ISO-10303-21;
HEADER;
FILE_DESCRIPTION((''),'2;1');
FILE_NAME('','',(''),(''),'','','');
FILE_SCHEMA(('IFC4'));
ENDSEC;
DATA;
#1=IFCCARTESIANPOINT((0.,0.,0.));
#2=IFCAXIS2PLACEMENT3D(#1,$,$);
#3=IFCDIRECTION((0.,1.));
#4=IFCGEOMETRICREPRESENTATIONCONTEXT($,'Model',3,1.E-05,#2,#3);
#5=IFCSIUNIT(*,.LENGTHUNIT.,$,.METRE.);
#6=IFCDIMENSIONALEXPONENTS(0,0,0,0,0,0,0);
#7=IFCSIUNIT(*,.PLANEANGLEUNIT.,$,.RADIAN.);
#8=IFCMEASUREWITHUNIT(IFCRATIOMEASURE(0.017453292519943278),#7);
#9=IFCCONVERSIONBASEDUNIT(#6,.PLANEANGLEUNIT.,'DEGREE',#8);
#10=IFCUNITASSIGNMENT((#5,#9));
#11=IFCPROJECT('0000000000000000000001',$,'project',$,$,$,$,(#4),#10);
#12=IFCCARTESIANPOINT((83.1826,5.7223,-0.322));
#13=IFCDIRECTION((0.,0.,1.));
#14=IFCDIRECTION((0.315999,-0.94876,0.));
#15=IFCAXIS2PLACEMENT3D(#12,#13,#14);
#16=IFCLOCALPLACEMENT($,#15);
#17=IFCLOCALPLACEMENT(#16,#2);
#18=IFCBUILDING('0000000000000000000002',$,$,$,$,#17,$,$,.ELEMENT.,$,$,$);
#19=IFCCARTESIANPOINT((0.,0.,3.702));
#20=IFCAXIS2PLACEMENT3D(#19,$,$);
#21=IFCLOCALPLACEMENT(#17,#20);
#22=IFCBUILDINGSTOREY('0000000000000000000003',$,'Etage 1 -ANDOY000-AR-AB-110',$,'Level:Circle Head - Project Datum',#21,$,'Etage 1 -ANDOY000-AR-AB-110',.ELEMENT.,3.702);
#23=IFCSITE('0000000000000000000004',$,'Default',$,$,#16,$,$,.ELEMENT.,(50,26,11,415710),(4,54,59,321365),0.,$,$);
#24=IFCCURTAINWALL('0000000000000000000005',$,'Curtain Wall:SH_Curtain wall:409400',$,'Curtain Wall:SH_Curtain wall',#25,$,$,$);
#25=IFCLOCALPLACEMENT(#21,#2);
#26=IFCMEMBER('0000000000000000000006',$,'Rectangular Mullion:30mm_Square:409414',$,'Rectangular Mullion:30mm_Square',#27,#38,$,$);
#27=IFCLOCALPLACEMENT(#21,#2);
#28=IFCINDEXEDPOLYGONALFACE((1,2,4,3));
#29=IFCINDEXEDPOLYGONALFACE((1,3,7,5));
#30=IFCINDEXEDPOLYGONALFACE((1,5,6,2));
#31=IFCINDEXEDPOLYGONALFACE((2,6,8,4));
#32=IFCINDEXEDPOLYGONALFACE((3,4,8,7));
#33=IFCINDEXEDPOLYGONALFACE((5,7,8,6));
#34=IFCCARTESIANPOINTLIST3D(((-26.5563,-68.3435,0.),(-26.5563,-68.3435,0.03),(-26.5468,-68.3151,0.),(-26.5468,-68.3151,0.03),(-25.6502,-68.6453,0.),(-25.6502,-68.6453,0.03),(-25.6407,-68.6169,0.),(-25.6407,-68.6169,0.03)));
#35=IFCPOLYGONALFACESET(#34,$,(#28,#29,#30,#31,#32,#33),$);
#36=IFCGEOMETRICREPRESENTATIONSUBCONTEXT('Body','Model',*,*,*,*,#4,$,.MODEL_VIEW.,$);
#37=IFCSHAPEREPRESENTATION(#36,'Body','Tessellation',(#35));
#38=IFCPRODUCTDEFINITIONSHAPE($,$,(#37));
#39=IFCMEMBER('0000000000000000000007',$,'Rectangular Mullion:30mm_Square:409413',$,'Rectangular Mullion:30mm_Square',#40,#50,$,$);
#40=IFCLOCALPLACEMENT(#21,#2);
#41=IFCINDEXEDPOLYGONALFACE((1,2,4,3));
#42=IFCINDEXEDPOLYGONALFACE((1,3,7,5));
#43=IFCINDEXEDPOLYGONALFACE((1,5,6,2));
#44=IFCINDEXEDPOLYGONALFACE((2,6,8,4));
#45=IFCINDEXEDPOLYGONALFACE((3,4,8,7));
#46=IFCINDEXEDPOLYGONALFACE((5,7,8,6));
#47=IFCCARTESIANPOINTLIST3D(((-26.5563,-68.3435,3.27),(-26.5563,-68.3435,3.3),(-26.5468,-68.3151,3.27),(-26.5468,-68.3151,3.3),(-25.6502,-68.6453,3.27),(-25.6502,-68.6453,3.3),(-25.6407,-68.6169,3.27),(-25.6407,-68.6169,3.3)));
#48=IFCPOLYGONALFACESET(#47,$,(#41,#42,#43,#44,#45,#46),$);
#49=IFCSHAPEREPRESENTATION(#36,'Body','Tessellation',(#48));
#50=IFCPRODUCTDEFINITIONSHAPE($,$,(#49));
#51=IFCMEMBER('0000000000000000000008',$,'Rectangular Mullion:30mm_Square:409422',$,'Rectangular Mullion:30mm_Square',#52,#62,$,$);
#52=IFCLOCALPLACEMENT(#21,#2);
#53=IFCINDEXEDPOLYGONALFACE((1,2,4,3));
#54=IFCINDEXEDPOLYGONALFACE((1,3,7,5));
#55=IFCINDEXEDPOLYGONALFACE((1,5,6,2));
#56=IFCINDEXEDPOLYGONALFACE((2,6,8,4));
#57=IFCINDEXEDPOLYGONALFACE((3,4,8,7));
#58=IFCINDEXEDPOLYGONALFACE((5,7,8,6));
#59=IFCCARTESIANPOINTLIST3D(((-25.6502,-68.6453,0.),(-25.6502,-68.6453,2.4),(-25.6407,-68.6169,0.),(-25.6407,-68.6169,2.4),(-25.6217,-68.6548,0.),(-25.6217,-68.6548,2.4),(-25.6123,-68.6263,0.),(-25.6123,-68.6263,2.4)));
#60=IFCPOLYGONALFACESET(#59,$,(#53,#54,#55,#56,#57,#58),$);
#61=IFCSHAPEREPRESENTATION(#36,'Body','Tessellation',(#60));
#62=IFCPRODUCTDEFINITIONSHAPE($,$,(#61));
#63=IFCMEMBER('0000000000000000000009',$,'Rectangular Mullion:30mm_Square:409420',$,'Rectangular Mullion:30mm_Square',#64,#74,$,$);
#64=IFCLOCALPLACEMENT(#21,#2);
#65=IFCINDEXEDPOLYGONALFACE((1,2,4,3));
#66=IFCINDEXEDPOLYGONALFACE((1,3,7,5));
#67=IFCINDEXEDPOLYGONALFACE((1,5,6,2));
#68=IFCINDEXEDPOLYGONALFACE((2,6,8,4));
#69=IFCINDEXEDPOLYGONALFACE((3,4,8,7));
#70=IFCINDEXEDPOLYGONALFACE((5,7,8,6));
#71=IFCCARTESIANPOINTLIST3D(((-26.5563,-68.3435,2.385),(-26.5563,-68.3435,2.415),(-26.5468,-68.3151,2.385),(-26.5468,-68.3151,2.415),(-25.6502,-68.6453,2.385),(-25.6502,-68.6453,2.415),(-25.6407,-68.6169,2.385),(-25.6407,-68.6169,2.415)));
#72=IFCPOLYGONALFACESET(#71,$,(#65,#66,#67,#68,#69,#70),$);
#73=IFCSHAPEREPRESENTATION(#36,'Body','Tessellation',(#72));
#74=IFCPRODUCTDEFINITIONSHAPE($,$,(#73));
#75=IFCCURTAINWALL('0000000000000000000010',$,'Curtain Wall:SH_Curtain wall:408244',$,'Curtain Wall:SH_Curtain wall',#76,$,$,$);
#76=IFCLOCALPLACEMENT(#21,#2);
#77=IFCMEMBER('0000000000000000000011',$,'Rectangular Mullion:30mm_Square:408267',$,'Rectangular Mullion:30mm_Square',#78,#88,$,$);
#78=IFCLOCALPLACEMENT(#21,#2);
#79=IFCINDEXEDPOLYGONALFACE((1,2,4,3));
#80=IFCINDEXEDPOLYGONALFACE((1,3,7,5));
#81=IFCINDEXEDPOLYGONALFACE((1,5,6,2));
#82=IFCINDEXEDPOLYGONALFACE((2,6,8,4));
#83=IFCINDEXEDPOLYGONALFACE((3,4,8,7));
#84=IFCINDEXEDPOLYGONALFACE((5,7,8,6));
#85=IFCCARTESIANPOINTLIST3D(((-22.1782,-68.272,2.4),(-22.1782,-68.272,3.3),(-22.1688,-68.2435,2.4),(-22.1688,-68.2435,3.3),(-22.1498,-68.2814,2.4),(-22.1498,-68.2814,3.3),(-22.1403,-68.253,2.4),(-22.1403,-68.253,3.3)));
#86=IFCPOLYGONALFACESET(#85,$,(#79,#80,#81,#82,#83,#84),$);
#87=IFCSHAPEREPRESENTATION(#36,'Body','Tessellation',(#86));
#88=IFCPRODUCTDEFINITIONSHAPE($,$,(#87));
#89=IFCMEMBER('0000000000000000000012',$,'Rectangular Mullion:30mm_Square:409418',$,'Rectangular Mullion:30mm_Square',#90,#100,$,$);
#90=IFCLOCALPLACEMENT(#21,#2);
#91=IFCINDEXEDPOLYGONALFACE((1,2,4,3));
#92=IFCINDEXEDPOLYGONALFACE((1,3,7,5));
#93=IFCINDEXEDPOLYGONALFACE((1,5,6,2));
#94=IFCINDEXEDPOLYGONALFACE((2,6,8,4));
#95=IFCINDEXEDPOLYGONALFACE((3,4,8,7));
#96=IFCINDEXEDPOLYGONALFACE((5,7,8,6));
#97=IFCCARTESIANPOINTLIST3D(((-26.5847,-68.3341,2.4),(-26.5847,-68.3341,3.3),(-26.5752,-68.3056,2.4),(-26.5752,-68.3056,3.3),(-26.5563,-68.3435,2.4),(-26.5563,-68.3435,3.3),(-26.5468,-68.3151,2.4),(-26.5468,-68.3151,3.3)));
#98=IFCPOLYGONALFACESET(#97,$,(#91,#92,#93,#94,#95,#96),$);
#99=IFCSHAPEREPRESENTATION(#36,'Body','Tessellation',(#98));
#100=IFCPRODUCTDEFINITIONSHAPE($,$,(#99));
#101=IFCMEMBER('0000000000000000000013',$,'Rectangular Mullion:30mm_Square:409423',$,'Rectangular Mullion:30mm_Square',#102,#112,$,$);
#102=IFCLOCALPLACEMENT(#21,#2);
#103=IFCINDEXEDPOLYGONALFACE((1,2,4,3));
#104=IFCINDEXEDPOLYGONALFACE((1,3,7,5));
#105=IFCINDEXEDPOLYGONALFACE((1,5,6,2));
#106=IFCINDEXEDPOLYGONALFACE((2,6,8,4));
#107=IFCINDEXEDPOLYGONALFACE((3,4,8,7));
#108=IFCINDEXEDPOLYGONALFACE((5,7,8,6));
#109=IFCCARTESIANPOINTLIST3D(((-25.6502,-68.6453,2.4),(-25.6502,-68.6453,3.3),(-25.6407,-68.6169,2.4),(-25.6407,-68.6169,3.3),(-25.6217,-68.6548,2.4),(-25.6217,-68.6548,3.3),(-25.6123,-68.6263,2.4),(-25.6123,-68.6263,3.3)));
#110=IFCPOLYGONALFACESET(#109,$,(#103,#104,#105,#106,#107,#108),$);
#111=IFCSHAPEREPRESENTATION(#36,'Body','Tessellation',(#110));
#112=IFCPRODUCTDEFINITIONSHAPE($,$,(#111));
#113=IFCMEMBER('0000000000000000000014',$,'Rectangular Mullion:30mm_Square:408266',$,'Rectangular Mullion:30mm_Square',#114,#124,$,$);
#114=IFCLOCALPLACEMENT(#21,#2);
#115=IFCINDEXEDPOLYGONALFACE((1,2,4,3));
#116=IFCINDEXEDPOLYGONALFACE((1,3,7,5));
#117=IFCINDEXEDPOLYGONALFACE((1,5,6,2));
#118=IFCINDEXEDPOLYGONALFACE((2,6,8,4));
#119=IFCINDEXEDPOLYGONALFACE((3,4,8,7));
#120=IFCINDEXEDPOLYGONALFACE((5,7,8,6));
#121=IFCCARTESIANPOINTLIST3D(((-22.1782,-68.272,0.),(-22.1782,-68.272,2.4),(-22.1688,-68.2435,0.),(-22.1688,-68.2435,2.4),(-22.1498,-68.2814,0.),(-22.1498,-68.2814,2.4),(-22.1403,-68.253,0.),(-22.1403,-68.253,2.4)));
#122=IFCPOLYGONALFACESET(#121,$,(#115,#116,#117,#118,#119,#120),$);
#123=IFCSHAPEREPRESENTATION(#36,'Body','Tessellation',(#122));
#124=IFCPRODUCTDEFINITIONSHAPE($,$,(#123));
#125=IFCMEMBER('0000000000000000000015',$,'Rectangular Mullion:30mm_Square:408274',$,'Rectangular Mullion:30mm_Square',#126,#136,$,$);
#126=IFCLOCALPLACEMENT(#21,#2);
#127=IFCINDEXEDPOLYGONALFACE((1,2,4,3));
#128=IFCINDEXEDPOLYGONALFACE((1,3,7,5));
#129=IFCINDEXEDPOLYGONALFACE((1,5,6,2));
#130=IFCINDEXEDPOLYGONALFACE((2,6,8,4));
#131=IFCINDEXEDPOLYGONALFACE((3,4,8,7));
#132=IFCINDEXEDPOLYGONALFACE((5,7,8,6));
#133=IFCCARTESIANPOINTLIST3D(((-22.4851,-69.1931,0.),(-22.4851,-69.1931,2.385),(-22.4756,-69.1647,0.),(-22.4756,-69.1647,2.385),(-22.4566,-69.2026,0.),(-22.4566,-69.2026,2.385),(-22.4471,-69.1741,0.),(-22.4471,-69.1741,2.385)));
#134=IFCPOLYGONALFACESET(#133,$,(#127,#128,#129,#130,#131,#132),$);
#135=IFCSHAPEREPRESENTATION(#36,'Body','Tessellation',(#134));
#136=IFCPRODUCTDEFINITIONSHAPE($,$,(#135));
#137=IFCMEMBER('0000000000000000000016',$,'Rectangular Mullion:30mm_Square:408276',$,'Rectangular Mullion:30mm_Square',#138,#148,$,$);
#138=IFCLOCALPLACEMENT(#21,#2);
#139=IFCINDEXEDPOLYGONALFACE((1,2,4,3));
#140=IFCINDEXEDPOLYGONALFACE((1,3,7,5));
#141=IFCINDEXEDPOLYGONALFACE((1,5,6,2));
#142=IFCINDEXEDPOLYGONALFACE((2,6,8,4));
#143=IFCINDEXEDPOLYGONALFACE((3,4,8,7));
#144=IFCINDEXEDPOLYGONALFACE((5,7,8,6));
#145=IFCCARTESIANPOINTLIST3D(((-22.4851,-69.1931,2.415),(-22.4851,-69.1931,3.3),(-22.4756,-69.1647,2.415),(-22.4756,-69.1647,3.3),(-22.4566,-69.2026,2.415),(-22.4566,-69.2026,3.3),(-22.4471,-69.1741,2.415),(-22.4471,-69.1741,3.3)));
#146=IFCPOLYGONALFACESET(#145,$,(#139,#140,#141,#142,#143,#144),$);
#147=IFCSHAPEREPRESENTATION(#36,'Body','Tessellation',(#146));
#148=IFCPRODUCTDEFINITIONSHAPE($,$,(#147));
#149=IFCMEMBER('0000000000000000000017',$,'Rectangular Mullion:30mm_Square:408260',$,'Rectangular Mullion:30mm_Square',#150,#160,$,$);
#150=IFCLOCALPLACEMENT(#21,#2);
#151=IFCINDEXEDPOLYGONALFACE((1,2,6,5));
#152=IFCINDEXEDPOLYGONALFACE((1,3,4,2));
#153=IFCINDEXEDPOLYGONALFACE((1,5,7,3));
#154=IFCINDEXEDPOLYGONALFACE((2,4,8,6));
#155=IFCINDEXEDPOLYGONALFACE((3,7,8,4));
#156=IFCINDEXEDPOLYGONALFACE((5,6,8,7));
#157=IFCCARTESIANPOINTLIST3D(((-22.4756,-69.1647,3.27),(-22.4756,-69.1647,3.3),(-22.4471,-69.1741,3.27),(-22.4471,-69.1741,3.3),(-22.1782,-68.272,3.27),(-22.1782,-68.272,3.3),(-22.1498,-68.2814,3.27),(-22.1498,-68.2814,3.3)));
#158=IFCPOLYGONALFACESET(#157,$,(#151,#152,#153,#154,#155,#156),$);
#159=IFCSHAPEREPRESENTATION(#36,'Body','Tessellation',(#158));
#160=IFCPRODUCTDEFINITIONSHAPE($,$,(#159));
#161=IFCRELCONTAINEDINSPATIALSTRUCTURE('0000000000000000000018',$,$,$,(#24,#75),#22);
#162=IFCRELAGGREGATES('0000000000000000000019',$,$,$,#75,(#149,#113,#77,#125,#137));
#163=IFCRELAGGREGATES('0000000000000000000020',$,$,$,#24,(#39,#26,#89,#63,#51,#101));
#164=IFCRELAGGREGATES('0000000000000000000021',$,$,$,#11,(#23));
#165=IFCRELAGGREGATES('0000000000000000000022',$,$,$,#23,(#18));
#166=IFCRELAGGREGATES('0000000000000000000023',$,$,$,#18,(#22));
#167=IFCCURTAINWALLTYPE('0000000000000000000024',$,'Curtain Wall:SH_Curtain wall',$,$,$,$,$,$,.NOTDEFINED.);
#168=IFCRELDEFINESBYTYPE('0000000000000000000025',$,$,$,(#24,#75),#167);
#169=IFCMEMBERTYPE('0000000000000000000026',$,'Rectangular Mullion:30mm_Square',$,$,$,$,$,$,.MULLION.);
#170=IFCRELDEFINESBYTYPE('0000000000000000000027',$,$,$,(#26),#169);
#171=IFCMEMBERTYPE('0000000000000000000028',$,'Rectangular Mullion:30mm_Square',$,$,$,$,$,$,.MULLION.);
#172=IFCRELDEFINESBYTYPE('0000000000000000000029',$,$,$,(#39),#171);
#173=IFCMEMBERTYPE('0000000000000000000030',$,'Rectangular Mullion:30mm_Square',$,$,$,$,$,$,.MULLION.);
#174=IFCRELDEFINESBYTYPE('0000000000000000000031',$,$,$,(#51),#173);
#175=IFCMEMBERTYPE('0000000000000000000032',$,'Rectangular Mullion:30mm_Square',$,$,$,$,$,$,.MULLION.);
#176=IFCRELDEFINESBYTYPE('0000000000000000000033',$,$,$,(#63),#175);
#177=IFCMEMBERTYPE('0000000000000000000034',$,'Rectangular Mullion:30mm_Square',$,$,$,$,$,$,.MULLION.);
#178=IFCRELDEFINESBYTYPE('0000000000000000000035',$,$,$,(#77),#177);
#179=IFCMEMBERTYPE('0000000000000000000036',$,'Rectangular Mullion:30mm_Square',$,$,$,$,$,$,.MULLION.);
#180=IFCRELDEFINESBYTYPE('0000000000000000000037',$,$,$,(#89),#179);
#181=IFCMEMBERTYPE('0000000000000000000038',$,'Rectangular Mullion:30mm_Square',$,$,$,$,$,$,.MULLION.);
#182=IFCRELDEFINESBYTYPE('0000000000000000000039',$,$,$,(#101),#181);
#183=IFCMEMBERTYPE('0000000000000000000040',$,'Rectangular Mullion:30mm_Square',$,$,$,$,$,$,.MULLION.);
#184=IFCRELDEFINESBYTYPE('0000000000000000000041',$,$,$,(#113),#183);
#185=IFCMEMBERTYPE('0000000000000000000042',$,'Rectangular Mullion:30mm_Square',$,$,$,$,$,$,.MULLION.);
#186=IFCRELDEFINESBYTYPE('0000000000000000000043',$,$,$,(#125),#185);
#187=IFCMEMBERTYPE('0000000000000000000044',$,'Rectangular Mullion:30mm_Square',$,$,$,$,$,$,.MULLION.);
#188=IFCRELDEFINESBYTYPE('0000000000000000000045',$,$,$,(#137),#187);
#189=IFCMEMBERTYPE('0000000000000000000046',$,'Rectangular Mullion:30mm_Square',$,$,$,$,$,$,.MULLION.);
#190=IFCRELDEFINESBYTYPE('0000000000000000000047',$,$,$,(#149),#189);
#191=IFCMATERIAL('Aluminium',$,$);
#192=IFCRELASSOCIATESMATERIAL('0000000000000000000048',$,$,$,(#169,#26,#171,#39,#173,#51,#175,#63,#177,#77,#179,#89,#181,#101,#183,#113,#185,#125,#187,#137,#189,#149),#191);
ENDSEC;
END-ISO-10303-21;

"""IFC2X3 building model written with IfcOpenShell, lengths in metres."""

from ifc_helpers import new_model, entity, si_unit, converted_unit, direction, frame, frame_2d, origin, origin_2d_with_axis, place, context, subcontext, project, spatial, rectangle, extrude, source, transform, mapped, material, type_object, type_shapes, element, aggregate, save


model = new_model("IFC2X3")

# Units and contexts
model_context = context("Model", 3, precision=1e-05, world=origin(), true_north=direction((0.0, 1.0)))
body_context = subcontext(model_context, "Body", "Model", "MODEL_VIEW")
ifc_project = project(units=[si_unit("LENGTHUNIT", "METRE"), converted_unit("PLANEANGLEUNIT", "DEGREE", entity("IfcRatioMeasure", 0.017453292519943278), si_unit("PLANEANGLEUNIT", "RADIAN"), dimensions=[0, 0, 0, 0, 0, 0, 0])], contexts=[model_context])

# Site, building, storey
site_placement = place(None, frame((83.1826, 5.7223, -0.322), z_axis=(0.0, 0.0, 1.0), x_axis=(0.315999, -0.94876, 0.0)))
site = spatial("IfcSite", under=ifc_project, at=site_placement, Name="Default", CompositionType="ELEMENT", RefLatitude=(50, 26, 11, 415710), RefLongitude=(4, 54, 59, 321365), RefElevation=0.0)
building_placement = place(site_placement, origin())
building = spatial("IfcBuilding", under=site, at=building_placement, CompositionType="ELEMENT")
storey_placement = place(building_placement, frame((0.0, 0.0, 3.702)))
storey = spatial("IfcBuildingStorey", under=building, at=storey_placement, Name="Etage 1 -ANDOY000-AR-AB-110", ObjectType="Level:Circle Head - Project Datum", LongName="Etage 1 -ANDOY000-AR-AB-110", CompositionType="ELEMENT", Elevation=3.702)

# Curtain wall, members
curtain_wall_type_1 = type_object("IfcCurtainWallType", Name="Curtain Wall:SH_Curtain wall", PredefinedType="NOTDEFINED")
curtain_wall_1_placement = place(storey_placement, frame((0.0, 0.0, -3.702)))
curtain_wall_1 = element("IfcCurtainWall", 1, at=curtain_wall_1_placement, inside=storey, type_object=curtain_wall_type_1, Name="Curtain Wall:SH_Curtain wall:409400", ObjectType="Curtain Wall:SH_Curtain wall")
ifc_material_1 = material(Name="Aluminium")
member_type_1 = type_object("IfcMemberType", Name="Rectangular Mullion:30mm_Square", PredefinedType="MULLION", material=ifc_material_1)
shared_shape_1 = source(origin(), body_context, "Body", "SweptSolid", [
    extrude(rectangle(XDim=0.03, YDim=0.03, at=origin_2d_with_axis()), frame((-0.015, 0.0, -0.955), z_axis=(0.0, 0.0, 1.0), x_axis=(0.0, -1.0, 0.0)), (0.0, 0.0, 1.0), 0.955),
])
type_shapes(member_type_1, [shared_shape_1])
member_1_placement = place(curtain_wall_1_placement, frame((-26.5515, -68.3293, 3.702), z_axis=(-0.948759, 0.316, 0.0), x_axis=(0.0, 0.0, -1.0)))
member_1 = element("IfcMember", 2, at=member_1_placement, type_object=member_type_1, material=ifc_material_1, Name="Rectangular Mullion:30mm_Square:409414", ObjectType="Rectangular Mullion:30mm_Square", context=body_context, shape_type="MappedRepresentation", body=[
    mapped(shared_shape_1, transform((0.0, 0.0, 0.0), scale=1.0)),
])
member_type_2 = type_object("IfcMemberType", Name="Rectangular Mullion:30mm_Square", PredefinedType="MULLION", material=ifc_material_1)
shared_shape_2 = source(origin(), body_context, "Body", "SweptSolid", [
    extrude(rectangle(XDim=0.03, YDim=0.03, at=origin_2d_with_axis()), frame((-0.015, 0.0, -0.955), z_axis=(0.0, 0.0, 1.0), x_axis=(0.0, -1.0, 0.0)), (0.0, 0.0, 1.0), 0.955),
])
type_shapes(member_type_2, [shared_shape_2])
member_2_placement = place(curtain_wall_1_placement, frame((-25.6455, -68.6311, 7.002), z_axis=(0.948759, -0.316, 0.0), x_axis=(0.0, 0.0, 1.0)))
member_2 = element("IfcMember", 3, at=member_2_placement, type_object=member_type_2, material=ifc_material_1, Name="Rectangular Mullion:30mm_Square:409413", ObjectType="Rectangular Mullion:30mm_Square", context=body_context, shape_type="MappedRepresentation", body=[
    mapped(shared_shape_2, transform((0.0, 0.0, 0.0), scale=1.0)),
])
member_type_3 = type_object("IfcMemberType", Name="Rectangular Mullion:30mm_Square", PredefinedType="MULLION", material=ifc_material_1)
shared_shape_3 = source(origin(), body_context, "Body", "SweptSolid", [
    extrude(rectangle(XDim=0.03, YDim=0.03, at=origin_2d_with_axis()), frame((0.0, 0.0, -2.4), z_axis=(0.0, 0.0, 1.0), x_axis=(0.0, -1.0, 0.0)), (0.0, 0.0, 1.0), 2.4),
])
type_shapes(member_type_3, [shared_shape_3])
member_3_placement = place(curtain_wall_1_placement, frame((-25.6312, -68.6358, 3.702), z_axis=(0.0, 0.0, -1.0), x_axis=(0.948759, -0.316, 0.0)))
member_3 = element("IfcMember", 4, at=member_3_placement, type_object=member_type_3, material=ifc_material_1, Name="Rectangular Mullion:30mm_Square:409422", ObjectType="Rectangular Mullion:30mm_Square", context=body_context, shape_type="MappedRepresentation", body=[
    mapped(shared_shape_3, transform((0.0, 0.0, 0.0), scale=1.0)),
])
member_type_4 = type_object("IfcMemberType", Name="Rectangular Mullion:30mm_Square", PredefinedType="MULLION", material=ifc_material_1)
shared_shape_4 = source(origin(), body_context, "Body", "SweptSolid", [
    extrude(rectangle(XDim=0.03, YDim=0.03, at=origin_2d_with_axis()), frame((0.0, 0.0, -0.955), z_axis=(0.0, 0.0, 1.0), x_axis=(0.0, -1.0, 0.0)), (0.0, 0.0, 1.0), 0.955),
])
type_shapes(member_type_4, [shared_shape_4])
member_4_placement = place(curtain_wall_1_placement, frame((-25.6455, -68.6311, 6.102), z_axis=(0.948759, -0.316, 0.0), x_axis=(0.0, 0.0, 1.0)))
member_4 = element("IfcMember", 5, at=member_4_placement, type_object=member_type_4, material=ifc_material_1, Name="Rectangular Mullion:30mm_Square:409420", ObjectType="Rectangular Mullion:30mm_Square", context=body_context, shape_type="MappedRepresentation", body=[
    mapped(shared_shape_4, transform((0.0, 0.0, 0.0), scale=1.0)),
])

# Curtain wall, member
curtain_wall_2_placement = place(storey_placement, frame((0.0, 0.0, -3.702)))
curtain_wall_2 = element("IfcCurtainWall", 6, at=curtain_wall_2_placement, inside=storey, type_object=curtain_wall_type_1, Name="Curtain Wall:SH_Curtain wall:408244", ObjectType="Curtain Wall:SH_Curtain wall")
member_type_5 = type_object("IfcMemberType", Name="Rectangular Mullion:30mm_Square", PredefinedType="MULLION", material=ifc_material_1)
shared_shape_5 = source(origin(), body_context, "Body", "SweptSolid", [
    extrude(rectangle(XDim=0.03, YDim=0.03, at=origin_2d_with_axis()), frame((-0.015, 0.0, -0.9), z_axis=(0.0, 0.0, 1.0), x_axis=(0.0, -1.0, 0.0)), (0.0, 0.0, 1.0), 0.9),
])
type_shapes(member_type_5, [shared_shape_5])
member_5_placement = place(curtain_wall_2_placement, frame((-22.1545, -68.2482, 6.102), z_axis=(0.0, 0.0, -1.0), x_axis=(0.316, 0.948759, 0.0)))
member_5 = element("IfcMember", 7, at=member_5_placement, type_object=member_type_5, material=ifc_material_1, Name="Rectangular Mullion:30mm_Square:408267", ObjectType="Rectangular Mullion:30mm_Square", context=body_context, shape_type="MappedRepresentation", body=[
    mapped(shared_shape_5, transform((0.0, 0.0, 0.0), scale=1.0)),
])

# Members
member_type_6 = type_object("IfcMemberType", Name="Rectangular Mullion:30mm_Square", PredefinedType="MULLION", material=ifc_material_1)
shared_shape_6 = source(origin(), body_context, "Body", "SweptSolid", [
    extrude(rectangle(XDim=0.03, YDim=0.03, at=origin_2d_with_axis()), frame((-0.015, 0.0, -0.9), z_axis=(0.0, 0.0, 1.0), x_axis=(0.0, -1.0, 0.0)), (0.0, 0.0, 1.0), 0.9),
])
type_shapes(member_type_6, [shared_shape_6])
member_6_placement = place(curtain_wall_1_placement, frame((-26.58, -68.3198, 7.002), z_axis=(0.0, 0.0, 1.0), x_axis=(-0.948759, 0.316, 0.0)))
member_6 = element("IfcMember", 8, at=member_6_placement, type_object=member_type_6, material=ifc_material_1, Name="Rectangular Mullion:30mm_Square:409418", ObjectType="Rectangular Mullion:30mm_Square", context=body_context, shape_type="MappedRepresentation", body=[
    mapped(shared_shape_6, transform((0.0, 0.0, 0.0), scale=1.0)),
])
member_type_7 = type_object("IfcMemberType", Name="Rectangular Mullion:30mm_Square", PredefinedType="MULLION", material=ifc_material_1)
shared_shape_7 = source(origin(), body_context, "Body", "SweptSolid", [
    extrude(rectangle(XDim=0.03, YDim=0.03, at=origin_2d_with_axis()), frame((0.0, 0.0, -0.9), z_axis=(0.0, 0.0, 1.0), x_axis=(0.0, -1.0, 0.0)), (0.0, 0.0, 1.0), 0.9),
])
type_shapes(member_type_7, [shared_shape_7])
member_7_placement = place(curtain_wall_1_placement, frame((-25.6312, -68.6358, 6.102), z_axis=(0.0, 0.0, -1.0), x_axis=(0.948759, -0.316, 0.0)))
member_7 = element("IfcMember", 9, at=member_7_placement, type_object=member_type_7, material=ifc_material_1, Name="Rectangular Mullion:30mm_Square:409423", ObjectType="Rectangular Mullion:30mm_Square", context=body_context, shape_type="MappedRepresentation", body=[
    mapped(shared_shape_7, transform((0.0, 0.0, 0.0), scale=1.0)),
])
member_type_8 = type_object("IfcMemberType", Name="Rectangular Mullion:30mm_Square", PredefinedType="MULLION", material=ifc_material_1)
shared_shape_8 = source(origin(), body_context, "Body", "SweptSolid", [
    extrude(rectangle(XDim=0.03, YDim=0.03, at=origin_2d_with_axis()), frame((-0.015, 0.0, -2.4), z_axis=(0.0, 0.0, 1.0), x_axis=(0.0, -1.0, 0.0)), (0.0, 0.0, 1.0), 2.4),
])
type_shapes(member_type_8, [shared_shape_8])
member_8_placement = place(curtain_wall_2_placement, frame((-22.1545, -68.2482, 3.702), z_axis=(0.0, 0.0, -1.0), x_axis=(0.316, 0.948759, 0.0)))
member_8 = element("IfcMember", 10, at=member_8_placement, type_object=member_type_8, material=ifc_material_1, Name="Rectangular Mullion:30mm_Square:408266", ObjectType="Rectangular Mullion:30mm_Square", context=body_context, shape_type="MappedRepresentation", body=[
    mapped(shared_shape_8, transform((0.0, 0.0, 0.0), scale=1.0)),
])
member_type_9 = type_object("IfcMemberType", Name="Rectangular Mullion:30mm_Square", PredefinedType="MULLION", material=ifc_material_1)
shared_shape_9 = source(origin(), body_context, "Body", "SweptSolid", [
    extrude(rectangle(XDim=0.03, YDim=0.03, at=origin_2d_with_axis()), frame((0.0, 0.0, -2.385), z_axis=(0.0, 0.0, 1.0), x_axis=(0.0, -1.0, 0.0)), (0.0, 0.0, 1.0), 2.385),
])
type_shapes(member_type_9, [shared_shape_9])
member_9_placement = place(curtain_wall_2_placement, frame((-22.4661, -69.1836, 3.702), z_axis=(0.0, 0.0, -1.0), x_axis=(0.316, 0.948759, 0.0)))
member_9 = element("IfcMember", 11, at=member_9_placement, type_object=member_type_9, material=ifc_material_1, Name="Rectangular Mullion:30mm_Square:408274", ObjectType="Rectangular Mullion:30mm_Square", context=body_context, shape_type="MappedRepresentation", body=[
    mapped(shared_shape_9, transform((0.0, 0.0, 0.0), scale=1.0)),
])
member_type_10 = type_object("IfcMemberType", Name="Rectangular Mullion:30mm_Square", PredefinedType="MULLION", material=ifc_material_1)
shared_shape_10 = source(origin(), body_context, "Body", "SweptSolid", [
    extrude(rectangle(XDim=0.03, YDim=0.03, at=origin_2d_with_axis()), frame((0.0, 0.0, -0.885), z_axis=(0.0, 0.0, 1.0), x_axis=(0.0, -1.0, 0.0)), (0.0, 0.0, 1.0), 0.885),
])
type_shapes(member_type_10, [shared_shape_10])
member_10_placement = place(curtain_wall_2_placement, frame((-22.4661, -69.1836, 6.117), z_axis=(0.0, 0.0, -1.0), x_axis=(0.316, 0.948759, 0.0)))
member_10 = element("IfcMember", 12, at=member_10_placement, type_object=member_type_10, material=ifc_material_1, Name="Rectangular Mullion:30mm_Square:408276", ObjectType="Rectangular Mullion:30mm_Square", context=body_context, shape_type="MappedRepresentation", body=[
    mapped(shared_shape_10, transform((0.0, 0.0, 0.0), scale=1.0)),
])
member_type_11 = type_object("IfcMemberType", Name="Rectangular Mullion:30mm_Square", PredefinedType="MULLION", material=ifc_material_1)
shared_shape_11 = source(origin(), body_context, "Body", "SweptSolid", [
    extrude(rectangle(XDim=0.03, YDim=0.03, at=frame_2d((0.0, 0.0), x_axis=(1.0, 0.0))), frame((-0.015, 0.0, -0.9409), z_axis=(0.0, 0.0, 1.0), x_axis=(0.0, -1.0, 0.0)), (0.0, 0.0, 1.0), 0.9409),
])
type_shapes(member_type_11, [shared_shape_11])
member_11_placement = place(curtain_wall_2_placement, frame((-22.164, -68.2767, 7.002), z_axis=(0.316, 0.948759, 0.0), x_axis=(0.0, 0.0, 1.0)))
member_11 = element("IfcMember", 13, at=member_11_placement, type_object=member_type_11, material=ifc_material_1, Name="Rectangular Mullion:30mm_Square:408260", ObjectType="Rectangular Mullion:30mm_Square", context=body_context, shape_type="MappedRepresentation", body=[
    mapped(shared_shape_11, transform((0.0, 0.0, 0.0), scale=1.0)),
])

aggregate(curtain_wall_2, [member_11, member_8, member_5, member_9, member_10])
aggregate(curtain_wall_1, [member_2, member_1, member_6, member_4, member_3, member_7])

save(model, "model.ifc")
